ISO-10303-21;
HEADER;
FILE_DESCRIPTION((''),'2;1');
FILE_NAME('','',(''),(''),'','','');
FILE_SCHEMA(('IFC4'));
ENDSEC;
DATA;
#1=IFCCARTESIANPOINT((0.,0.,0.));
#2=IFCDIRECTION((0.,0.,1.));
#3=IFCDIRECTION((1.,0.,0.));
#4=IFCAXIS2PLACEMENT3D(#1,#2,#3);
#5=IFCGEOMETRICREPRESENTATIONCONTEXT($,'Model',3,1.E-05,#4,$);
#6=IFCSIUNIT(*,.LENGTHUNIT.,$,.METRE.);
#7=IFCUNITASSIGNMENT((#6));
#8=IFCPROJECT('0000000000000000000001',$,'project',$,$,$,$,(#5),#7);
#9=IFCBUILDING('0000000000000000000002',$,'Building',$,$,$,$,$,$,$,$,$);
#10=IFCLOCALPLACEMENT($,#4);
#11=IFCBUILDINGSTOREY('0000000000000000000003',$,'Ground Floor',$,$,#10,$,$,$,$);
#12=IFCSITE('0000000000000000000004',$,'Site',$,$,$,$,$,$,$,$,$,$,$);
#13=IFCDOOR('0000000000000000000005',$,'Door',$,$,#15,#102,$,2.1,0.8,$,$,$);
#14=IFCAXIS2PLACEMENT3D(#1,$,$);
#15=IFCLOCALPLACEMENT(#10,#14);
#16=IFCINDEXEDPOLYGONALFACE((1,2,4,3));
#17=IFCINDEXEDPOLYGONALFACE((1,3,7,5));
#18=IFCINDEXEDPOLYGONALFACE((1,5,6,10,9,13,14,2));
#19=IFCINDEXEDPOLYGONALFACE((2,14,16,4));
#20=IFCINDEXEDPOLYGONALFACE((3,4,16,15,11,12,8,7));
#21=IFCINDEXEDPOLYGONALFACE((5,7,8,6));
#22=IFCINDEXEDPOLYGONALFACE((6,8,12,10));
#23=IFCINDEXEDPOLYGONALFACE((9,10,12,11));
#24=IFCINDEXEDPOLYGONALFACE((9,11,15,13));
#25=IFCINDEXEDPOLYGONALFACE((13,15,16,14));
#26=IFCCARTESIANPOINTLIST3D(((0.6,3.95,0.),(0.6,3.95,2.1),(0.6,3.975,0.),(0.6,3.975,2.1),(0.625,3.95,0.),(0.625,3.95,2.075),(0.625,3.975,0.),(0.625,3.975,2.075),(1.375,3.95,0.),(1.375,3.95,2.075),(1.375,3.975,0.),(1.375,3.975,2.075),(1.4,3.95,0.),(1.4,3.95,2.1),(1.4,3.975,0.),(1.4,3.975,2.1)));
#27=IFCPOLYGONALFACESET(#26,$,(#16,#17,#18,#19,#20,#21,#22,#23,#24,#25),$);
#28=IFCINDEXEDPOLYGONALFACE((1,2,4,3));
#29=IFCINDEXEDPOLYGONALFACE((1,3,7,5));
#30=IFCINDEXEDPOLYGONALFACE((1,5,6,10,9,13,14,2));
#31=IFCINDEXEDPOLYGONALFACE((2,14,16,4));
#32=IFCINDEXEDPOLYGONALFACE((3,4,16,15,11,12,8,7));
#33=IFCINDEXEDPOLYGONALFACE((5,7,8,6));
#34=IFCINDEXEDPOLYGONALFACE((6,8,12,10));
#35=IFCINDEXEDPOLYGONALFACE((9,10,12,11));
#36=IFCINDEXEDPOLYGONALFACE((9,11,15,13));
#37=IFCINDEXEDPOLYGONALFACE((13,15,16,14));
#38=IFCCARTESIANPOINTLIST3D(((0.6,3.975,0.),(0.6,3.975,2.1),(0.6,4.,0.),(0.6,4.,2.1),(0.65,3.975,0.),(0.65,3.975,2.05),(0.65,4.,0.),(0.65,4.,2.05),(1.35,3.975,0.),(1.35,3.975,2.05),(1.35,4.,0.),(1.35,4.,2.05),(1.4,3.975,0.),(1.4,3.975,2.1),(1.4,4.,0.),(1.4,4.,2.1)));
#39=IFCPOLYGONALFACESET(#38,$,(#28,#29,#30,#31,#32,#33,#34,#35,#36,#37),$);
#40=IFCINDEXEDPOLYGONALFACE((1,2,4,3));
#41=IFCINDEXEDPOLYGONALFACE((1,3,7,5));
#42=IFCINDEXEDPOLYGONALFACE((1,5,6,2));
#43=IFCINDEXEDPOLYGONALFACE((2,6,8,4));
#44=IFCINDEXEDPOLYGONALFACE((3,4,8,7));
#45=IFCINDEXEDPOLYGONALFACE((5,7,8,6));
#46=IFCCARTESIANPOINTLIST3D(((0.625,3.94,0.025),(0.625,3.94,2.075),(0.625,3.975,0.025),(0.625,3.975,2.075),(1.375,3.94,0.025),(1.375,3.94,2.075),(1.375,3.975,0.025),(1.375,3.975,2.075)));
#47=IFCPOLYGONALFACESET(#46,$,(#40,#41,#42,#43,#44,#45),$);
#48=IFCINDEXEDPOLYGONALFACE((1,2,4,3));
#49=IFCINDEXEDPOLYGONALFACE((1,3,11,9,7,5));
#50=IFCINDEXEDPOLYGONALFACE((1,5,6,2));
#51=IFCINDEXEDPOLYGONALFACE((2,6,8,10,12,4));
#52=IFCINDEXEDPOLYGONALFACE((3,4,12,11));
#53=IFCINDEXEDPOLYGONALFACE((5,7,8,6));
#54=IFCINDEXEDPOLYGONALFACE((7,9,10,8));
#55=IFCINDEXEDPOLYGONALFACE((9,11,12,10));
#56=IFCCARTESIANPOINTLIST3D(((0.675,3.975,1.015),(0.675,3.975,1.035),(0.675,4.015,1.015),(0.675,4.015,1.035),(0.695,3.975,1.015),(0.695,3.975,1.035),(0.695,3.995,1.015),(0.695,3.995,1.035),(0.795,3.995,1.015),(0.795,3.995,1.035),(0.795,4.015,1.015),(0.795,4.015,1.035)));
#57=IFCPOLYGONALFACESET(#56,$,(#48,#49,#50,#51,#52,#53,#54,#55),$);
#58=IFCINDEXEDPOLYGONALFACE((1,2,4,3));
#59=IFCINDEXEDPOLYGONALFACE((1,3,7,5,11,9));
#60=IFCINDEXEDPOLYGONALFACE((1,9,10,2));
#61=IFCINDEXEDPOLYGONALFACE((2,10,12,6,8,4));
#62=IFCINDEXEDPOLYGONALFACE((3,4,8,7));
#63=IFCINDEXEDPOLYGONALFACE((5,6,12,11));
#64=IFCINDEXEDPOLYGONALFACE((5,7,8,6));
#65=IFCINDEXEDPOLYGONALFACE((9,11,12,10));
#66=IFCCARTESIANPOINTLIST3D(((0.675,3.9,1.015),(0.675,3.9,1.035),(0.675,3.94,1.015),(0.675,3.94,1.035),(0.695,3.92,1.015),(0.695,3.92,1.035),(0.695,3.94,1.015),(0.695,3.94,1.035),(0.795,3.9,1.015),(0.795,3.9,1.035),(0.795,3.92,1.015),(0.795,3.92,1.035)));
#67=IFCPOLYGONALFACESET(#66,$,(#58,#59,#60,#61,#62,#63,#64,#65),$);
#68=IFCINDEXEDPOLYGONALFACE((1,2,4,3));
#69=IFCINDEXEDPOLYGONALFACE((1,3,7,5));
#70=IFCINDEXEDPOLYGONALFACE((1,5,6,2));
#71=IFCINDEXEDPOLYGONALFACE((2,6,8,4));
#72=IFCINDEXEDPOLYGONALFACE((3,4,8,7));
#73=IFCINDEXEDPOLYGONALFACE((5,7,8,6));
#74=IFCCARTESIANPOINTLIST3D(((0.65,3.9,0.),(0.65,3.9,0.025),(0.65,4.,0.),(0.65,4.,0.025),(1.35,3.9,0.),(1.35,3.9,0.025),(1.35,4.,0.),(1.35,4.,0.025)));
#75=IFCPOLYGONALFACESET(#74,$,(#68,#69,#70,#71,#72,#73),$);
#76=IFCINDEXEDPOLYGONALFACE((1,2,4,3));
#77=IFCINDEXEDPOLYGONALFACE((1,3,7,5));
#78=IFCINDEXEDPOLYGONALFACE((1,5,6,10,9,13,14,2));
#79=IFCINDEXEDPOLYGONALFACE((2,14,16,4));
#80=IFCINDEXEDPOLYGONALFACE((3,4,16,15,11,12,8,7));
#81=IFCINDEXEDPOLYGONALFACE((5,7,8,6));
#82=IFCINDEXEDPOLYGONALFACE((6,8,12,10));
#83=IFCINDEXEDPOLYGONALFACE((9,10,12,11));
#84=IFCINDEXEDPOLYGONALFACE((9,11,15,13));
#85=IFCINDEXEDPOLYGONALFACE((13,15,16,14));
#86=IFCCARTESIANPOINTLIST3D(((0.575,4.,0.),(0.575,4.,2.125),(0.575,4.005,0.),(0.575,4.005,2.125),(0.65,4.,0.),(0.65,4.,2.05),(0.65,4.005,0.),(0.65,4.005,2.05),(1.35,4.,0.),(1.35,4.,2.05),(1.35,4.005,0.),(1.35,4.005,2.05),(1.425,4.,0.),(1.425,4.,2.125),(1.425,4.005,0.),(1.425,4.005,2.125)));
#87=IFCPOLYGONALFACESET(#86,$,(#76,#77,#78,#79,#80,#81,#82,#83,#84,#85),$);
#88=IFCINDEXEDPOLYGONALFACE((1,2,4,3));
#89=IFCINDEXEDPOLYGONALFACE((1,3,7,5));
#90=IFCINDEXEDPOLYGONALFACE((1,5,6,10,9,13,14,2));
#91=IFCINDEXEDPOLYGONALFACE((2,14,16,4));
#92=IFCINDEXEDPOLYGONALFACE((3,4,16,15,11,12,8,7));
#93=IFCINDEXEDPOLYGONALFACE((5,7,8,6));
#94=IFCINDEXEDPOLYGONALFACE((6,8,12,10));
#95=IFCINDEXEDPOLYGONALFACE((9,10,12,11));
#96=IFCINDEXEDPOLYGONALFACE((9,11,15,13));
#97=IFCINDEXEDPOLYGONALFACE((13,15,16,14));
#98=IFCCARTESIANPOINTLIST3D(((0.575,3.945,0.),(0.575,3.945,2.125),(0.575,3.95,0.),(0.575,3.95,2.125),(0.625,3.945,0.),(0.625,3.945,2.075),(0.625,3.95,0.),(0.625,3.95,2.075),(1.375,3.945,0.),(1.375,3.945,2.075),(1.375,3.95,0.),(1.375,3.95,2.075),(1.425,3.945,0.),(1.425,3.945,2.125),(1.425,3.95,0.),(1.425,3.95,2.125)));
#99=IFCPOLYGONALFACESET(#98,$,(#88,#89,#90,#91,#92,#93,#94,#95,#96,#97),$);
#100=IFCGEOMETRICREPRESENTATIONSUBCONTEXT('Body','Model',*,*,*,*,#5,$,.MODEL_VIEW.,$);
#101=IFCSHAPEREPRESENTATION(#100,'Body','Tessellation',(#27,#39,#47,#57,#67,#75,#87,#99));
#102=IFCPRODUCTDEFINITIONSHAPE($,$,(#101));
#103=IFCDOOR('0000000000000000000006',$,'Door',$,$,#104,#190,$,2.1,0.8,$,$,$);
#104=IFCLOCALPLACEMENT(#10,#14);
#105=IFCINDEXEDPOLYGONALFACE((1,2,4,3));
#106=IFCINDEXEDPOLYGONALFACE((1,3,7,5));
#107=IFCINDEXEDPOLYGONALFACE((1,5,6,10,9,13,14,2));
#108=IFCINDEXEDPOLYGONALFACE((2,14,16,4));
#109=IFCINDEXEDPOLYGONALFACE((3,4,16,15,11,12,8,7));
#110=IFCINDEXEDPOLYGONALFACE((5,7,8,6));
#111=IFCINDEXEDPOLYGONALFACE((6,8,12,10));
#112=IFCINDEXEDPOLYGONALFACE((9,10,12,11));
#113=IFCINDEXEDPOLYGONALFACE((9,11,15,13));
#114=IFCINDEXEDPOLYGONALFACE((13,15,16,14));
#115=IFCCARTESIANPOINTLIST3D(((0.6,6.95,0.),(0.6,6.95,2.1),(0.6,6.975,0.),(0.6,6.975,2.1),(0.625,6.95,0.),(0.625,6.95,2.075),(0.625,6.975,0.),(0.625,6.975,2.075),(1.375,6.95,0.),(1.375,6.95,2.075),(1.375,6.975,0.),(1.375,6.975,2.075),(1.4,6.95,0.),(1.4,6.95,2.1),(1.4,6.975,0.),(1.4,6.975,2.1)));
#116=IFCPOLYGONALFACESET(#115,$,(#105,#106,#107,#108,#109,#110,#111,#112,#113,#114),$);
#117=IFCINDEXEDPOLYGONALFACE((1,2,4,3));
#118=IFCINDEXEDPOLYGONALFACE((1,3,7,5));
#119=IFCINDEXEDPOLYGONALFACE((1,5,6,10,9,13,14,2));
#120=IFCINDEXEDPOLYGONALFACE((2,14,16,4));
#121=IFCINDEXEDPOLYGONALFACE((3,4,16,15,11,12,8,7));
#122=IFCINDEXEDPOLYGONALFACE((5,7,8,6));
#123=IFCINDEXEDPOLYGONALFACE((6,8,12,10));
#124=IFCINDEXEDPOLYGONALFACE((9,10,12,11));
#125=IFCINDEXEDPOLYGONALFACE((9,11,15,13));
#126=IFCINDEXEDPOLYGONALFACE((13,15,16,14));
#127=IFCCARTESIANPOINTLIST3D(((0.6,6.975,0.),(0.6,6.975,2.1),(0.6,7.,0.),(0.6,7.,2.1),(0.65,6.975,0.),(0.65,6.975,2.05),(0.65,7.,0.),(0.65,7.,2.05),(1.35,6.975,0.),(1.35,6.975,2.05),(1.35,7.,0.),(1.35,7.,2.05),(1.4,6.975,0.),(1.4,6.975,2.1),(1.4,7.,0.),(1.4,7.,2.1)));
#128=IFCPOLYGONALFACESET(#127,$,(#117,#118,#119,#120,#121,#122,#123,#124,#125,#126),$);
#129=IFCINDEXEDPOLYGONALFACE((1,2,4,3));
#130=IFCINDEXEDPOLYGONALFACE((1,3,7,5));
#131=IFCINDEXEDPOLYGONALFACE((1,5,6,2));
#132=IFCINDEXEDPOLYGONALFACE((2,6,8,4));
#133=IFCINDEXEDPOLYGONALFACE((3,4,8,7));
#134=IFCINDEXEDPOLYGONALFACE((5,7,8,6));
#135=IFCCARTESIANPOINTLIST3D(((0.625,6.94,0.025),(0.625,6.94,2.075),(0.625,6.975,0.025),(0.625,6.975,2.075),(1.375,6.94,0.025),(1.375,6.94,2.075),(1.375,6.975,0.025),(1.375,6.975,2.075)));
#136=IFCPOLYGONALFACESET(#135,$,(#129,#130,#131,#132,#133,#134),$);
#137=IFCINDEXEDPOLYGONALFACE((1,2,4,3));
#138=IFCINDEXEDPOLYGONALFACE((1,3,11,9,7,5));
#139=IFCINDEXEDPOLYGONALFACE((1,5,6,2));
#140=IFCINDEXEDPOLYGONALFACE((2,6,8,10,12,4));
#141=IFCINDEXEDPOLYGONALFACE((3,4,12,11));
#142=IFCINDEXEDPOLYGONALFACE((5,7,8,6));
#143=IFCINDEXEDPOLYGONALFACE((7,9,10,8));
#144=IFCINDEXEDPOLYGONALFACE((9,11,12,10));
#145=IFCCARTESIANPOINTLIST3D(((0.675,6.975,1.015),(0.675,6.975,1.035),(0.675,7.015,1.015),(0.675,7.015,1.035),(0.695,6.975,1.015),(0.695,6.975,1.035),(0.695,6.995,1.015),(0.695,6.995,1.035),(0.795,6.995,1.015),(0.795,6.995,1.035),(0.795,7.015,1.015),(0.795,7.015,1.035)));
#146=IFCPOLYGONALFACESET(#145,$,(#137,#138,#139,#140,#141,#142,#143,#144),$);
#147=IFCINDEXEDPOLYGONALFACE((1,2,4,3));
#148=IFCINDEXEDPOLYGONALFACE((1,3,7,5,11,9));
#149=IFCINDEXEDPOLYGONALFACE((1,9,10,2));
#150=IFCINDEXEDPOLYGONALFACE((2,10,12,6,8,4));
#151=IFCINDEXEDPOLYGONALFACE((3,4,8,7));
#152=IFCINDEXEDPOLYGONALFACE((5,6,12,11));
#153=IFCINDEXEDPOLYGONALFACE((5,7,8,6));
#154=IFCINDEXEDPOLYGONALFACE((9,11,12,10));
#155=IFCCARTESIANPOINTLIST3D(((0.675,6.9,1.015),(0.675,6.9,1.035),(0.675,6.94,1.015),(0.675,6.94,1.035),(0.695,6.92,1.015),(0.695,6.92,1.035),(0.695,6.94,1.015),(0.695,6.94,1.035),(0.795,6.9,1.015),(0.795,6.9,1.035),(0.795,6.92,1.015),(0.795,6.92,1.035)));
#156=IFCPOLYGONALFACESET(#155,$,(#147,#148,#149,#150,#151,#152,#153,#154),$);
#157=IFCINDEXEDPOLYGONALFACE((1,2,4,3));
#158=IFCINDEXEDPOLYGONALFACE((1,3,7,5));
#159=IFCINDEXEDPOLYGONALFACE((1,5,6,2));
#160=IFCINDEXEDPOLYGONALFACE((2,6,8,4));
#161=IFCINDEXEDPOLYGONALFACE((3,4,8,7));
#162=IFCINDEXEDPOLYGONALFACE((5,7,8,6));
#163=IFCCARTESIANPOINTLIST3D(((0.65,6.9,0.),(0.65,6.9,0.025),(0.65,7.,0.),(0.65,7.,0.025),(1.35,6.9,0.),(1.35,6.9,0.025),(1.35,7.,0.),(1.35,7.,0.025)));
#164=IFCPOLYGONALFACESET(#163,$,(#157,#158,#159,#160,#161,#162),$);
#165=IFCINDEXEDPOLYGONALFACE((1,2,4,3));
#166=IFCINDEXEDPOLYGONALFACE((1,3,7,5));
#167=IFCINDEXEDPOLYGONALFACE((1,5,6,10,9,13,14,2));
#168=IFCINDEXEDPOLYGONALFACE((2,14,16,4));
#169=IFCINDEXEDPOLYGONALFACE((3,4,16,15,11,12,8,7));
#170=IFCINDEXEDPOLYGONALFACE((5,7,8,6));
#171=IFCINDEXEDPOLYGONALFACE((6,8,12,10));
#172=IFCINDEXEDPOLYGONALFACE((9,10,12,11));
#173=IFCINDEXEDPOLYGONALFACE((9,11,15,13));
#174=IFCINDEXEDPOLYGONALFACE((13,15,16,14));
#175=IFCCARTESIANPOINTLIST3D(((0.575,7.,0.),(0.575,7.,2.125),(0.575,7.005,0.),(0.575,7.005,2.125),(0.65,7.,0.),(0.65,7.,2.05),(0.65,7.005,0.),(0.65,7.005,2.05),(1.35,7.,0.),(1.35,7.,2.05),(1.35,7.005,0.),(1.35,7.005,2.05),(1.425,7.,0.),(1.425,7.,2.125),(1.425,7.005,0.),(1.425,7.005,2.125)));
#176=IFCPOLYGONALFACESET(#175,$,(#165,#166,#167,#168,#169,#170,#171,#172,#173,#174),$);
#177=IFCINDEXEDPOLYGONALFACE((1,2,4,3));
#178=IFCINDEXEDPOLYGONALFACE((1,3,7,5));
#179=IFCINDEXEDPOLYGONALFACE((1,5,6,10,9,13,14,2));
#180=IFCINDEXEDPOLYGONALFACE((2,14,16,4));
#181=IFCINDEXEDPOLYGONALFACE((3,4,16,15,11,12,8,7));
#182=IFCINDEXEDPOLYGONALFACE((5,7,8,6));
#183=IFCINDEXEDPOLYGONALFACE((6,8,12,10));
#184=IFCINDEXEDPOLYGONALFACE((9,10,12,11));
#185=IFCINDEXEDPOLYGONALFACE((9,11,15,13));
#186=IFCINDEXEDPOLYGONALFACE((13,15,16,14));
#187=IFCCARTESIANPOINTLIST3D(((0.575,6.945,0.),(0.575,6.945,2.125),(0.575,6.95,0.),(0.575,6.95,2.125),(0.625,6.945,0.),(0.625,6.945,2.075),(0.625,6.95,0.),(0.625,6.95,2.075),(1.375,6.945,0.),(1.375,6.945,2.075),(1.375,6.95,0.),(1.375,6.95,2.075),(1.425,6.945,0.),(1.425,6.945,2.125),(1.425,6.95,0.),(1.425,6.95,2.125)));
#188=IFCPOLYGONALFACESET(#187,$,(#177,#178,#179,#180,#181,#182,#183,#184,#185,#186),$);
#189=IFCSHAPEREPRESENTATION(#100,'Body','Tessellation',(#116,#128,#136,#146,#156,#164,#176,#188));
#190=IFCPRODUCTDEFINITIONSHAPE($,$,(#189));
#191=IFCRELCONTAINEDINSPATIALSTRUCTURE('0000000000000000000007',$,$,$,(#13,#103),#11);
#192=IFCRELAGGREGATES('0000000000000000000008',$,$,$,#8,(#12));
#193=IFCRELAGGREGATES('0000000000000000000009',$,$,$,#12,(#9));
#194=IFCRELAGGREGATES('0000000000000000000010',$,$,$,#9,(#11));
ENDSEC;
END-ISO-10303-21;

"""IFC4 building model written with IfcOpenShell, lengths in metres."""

from ifc_helpers import new_model, si_unit, frame, origin_with_axes, place, context, subcontext, project, spatial, line, indexed_curve, outline, extrude, element, save


model = new_model("IFC4")

# Units and contexts
model_context = context("Model", 3, precision=1e-05, world=origin_with_axes())
body_context = subcontext(model_context, "Body", "Model", "MODEL_VIEW")
ifc_project = project(units=[si_unit("LENGTHUNIT", "METRE")], contexts=[model_context])

# Site, building, storey
site = spatial("IfcSite", under=ifc_project, Name="Site")
building = spatial("IfcBuilding", under=site, Name="Building")
storey_placement = place(None, origin_with_axes())
storey = spatial("IfcBuildingStorey", under=building, at=storey_placement, Name="Ground Floor")

# Doors
door_1_placement = place(storey_placement, frame((1.4, 4.0, 0.0), z_axis=(0.0, 0.0, 1.0), x_axis=(-1.0, 0.0, 0.0)))
element("IfcDoor", 1, at=door_1_placement, inside=storey, Name="Door", OverallHeight=2.1, OverallWidth=0.8, context=body_context, shape_type="SweptSolid", body=[
    extrude(outline(indexed_curve([(0.0, 0.0), (0.0, 2.1), (0.8, 2.1), (0.8, 0.0), (0.775, 0.0), (0.775, 2.075), (0.025, 2.075), (0.025, 0.0)], segments=[line(1, 2, 3, 4, 5, 6, 7, 8, 1)])), frame((0.0, 0.025, 0.0), z_axis=(0.0, -1.0, 0.0), x_axis=(1.0, 0.0, 0.0)), (0.0, 0.0, -1.0), 0.025),
    extrude(outline(indexed_curve([(0.0, 0.0), (0.0, 2.1), (0.8, 2.1), (0.8, 0.0), (0.75, 0.0), (0.75, 2.05), (0.05, 2.05), (0.05, 0.0)], segments=[line(1, 2, 3, 4, 5, 6, 7, 8, 1)])), frame((0.0, 0.0, 0.0), z_axis=(0.0, -1.0, 0.0), x_axis=(1.0, 0.0, 0.0)), (0.0, 0.0, -1.0), 0.025),
    extrude(outline(indexed_curve([(0.0, 0.0), (0.75, 0.0), (0.75, 0.035), (0.0, 0.035)], segments=[line(1, 2, 3, 4, 1)])), frame((0.025, 0.025, 0.025), z_axis=(0.0, 0.0, 1.0), x_axis=(1.0, 0.0, 0.0)), (0.0, 0.0, 1.0), 2.05),
    extrude(outline(indexed_curve([(0.0, 0.0), (0.0, -0.04), (-0.12, -0.04), (-0.12, -0.02), (-0.02, -0.02), (-0.02, 0.0)], segments=[line(1, 2, 3, 4, 5, 6, 1)])), frame((0.725, 0.025, 1.015), z_axis=(0.0, 0.0, 1.0), x_axis=(1.0, 0.0, 0.0)), (0.0, 0.0, 1.0), 0.02),
    extrude(outline(indexed_curve([(0.0, 0.0), (0.0, 0.04), (-0.12, 0.04), (-0.12, 0.02), (-0.02, 0.02), (-0.02, 0.0)], segments=[line(1, 2, 3, 4, 5, 6, 1)])), frame((0.725, 0.06, 1.015), z_axis=(0.0, 0.0, 1.0), x_axis=(1.0, 0.0, 0.0)), (0.0, 0.0, 1.0), 0.02),
    extrude(outline(indexed_curve([(0.0, 0.0), (0.7, 0.0), (0.7, 0.1), (0.0, 0.1)], segments=[line(1, 2, 3, 4, 1)])), frame((0.05, 0.0, 0.0), z_axis=(0.0, 0.0, 1.0), x_axis=(1.0, 0.0, 0.0)), (0.0, 0.0, 1.0), 0.025),
    extrude(outline(indexed_curve([(0.0, 0.0), (0.0, 2.125), (0.85, 2.125), (0.85, 0.0), (0.775, 0.0), (0.775, 2.05), (0.075, 2.05), (0.075, 0.0)], segments=[line(1, 2, 3, 4, 5, 6, 7, 8, 1)])), frame((-0.025, -0.005, 0.0), z_axis=(0.0, -1.0, 0.0), x_axis=(1.0, 0.0, 0.0)), (0.0, 0.0, -1.0), 0.005),
    extrude(outline(indexed_curve([(0.0, 0.0), (0.0, 2.125), (0.85, 2.125), (0.85, 0.0), (0.8, 0.0), (0.8, 2.075), (0.05, 2.075), (0.05, 0.0)], segments=[line(1, 2, 3, 4, 5, 6, 7, 8, 1)])), frame((-0.025, 0.05, 0.0), z_axis=(0.0, -1.0, 0.0), x_axis=(1.0, 0.0, 0.0)), (0.0, 0.0, -1.0), 0.005),
])
door_2_placement = place(storey_placement, frame((1.4, 7.0, 0.0), z_axis=(0.0, 0.0, 1.0), x_axis=(-1.0, 0.0, 0.0)))
element("IfcDoor", 2, at=door_2_placement, inside=storey, Name="Door", OverallHeight=2.1, OverallWidth=0.8, context=body_context, shape_type="SweptSolid", body=[
    extrude(outline(indexed_curve([(0.0, 0.0), (0.0, 2.1), (0.8, 2.1), (0.8, 0.0), (0.775, 0.0), (0.775, 2.075), (0.025, 2.075), (0.025, 0.0)], segments=[line(1, 2, 3, 4, 5, 6, 7, 8, 1)])), frame((0.0, 0.025, 0.0), z_axis=(0.0, -1.0, 0.0), x_axis=(1.0, 0.0, 0.0)), (0.0, 0.0, -1.0), 0.025),
    extrude(outline(indexed_curve([(0.0, 0.0), (0.0, 2.1), (0.8, 2.1), (0.8, 0.0), (0.75, 0.0), (0.75, 2.05), (0.05, 2.05), (0.05, 0.0)], segments=[line(1, 2, 3, 4, 5, 6, 7, 8, 1)])), frame((0.0, 0.0, 0.0), z_axis=(0.0, -1.0, 0.0), x_axis=(1.0, 0.0, 0.0)), (0.0, 0.0, -1.0), 0.025),
    extrude(outline(indexed_curve([(0.0, 0.0), (0.75, 0.0), (0.75, 0.035), (0.0, 0.035)], segments=[line(1, 2, 3, 4, 1)])), frame((0.025, 0.025, 0.025), z_axis=(0.0, 0.0, 1.0), x_axis=(1.0, 0.0, 0.0)), (0.0, 0.0, 1.0), 2.05),
    extrude(outline(indexed_curve([(0.0, 0.0), (0.0, -0.04), (-0.12, -0.04), (-0.12, -0.02), (-0.02, -0.02), (-0.02, 0.0)], segments=[line(1, 2, 3, 4, 5, 6, 1)])), frame((0.725, 0.025, 1.015), z_axis=(0.0, 0.0, 1.0), x_axis=(1.0, 0.0, 0.0)), (0.0, 0.0, 1.0), 0.02),
    extrude(outline(indexed_curve([(0.0, 0.0), (0.0, 0.04), (-0.12, 0.04), (-0.12, 0.02), (-0.02, 0.02), (-0.02, 0.0)], segments=[line(1, 2, 3, 4, 5, 6, 1)])), frame((0.725, 0.06, 1.015), z_axis=(0.0, 0.0, 1.0), x_axis=(1.0, 0.0, 0.0)), (0.0, 0.0, 1.0), 0.02),
    extrude(outline(indexed_curve([(0.0, 0.0), (0.7, 0.0), (0.7, 0.1), (0.0, 0.1)], segments=[line(1, 2, 3, 4, 1)])), frame((0.05, 0.0, 0.0), z_axis=(0.0, 0.0, 1.0), x_axis=(1.0, 0.0, 0.0)), (0.0, 0.0, 1.0), 0.025),
    extrude(outline(indexed_curve([(0.0, 0.0), (0.0, 2.125), (0.85, 2.125), (0.85, 0.0), (0.775, 0.0), (0.775, 2.05), (0.075, 2.05), (0.075, 0.0)], segments=[line(1, 2, 3, 4, 5, 6, 7, 8, 1)])), frame((-0.025, -0.005, 0.0), z_axis=(0.0, -1.0, 0.0), x_axis=(1.0, 0.0, 0.0)), (0.0, 0.0, -1.0), 0.005),
    extrude(outline(indexed_curve([(0.0, 0.0), (0.0, 2.125), (0.85, 2.125), (0.85, 0.0), (0.8, 0.0), (0.8, 2.075), (0.05, 2.075), (0.05, 0.0)], segments=[line(1, 2, 3, 4, 5, 6, 7, 8, 1)])), frame((-0.025, 0.05, 0.0), z_axis=(0.0, -1.0, 0.0), x_axis=(1.0, 0.0, 0.0)), (0.0, 0.0, -1.0), 0.005),
])

save(model, "model.ifc")
